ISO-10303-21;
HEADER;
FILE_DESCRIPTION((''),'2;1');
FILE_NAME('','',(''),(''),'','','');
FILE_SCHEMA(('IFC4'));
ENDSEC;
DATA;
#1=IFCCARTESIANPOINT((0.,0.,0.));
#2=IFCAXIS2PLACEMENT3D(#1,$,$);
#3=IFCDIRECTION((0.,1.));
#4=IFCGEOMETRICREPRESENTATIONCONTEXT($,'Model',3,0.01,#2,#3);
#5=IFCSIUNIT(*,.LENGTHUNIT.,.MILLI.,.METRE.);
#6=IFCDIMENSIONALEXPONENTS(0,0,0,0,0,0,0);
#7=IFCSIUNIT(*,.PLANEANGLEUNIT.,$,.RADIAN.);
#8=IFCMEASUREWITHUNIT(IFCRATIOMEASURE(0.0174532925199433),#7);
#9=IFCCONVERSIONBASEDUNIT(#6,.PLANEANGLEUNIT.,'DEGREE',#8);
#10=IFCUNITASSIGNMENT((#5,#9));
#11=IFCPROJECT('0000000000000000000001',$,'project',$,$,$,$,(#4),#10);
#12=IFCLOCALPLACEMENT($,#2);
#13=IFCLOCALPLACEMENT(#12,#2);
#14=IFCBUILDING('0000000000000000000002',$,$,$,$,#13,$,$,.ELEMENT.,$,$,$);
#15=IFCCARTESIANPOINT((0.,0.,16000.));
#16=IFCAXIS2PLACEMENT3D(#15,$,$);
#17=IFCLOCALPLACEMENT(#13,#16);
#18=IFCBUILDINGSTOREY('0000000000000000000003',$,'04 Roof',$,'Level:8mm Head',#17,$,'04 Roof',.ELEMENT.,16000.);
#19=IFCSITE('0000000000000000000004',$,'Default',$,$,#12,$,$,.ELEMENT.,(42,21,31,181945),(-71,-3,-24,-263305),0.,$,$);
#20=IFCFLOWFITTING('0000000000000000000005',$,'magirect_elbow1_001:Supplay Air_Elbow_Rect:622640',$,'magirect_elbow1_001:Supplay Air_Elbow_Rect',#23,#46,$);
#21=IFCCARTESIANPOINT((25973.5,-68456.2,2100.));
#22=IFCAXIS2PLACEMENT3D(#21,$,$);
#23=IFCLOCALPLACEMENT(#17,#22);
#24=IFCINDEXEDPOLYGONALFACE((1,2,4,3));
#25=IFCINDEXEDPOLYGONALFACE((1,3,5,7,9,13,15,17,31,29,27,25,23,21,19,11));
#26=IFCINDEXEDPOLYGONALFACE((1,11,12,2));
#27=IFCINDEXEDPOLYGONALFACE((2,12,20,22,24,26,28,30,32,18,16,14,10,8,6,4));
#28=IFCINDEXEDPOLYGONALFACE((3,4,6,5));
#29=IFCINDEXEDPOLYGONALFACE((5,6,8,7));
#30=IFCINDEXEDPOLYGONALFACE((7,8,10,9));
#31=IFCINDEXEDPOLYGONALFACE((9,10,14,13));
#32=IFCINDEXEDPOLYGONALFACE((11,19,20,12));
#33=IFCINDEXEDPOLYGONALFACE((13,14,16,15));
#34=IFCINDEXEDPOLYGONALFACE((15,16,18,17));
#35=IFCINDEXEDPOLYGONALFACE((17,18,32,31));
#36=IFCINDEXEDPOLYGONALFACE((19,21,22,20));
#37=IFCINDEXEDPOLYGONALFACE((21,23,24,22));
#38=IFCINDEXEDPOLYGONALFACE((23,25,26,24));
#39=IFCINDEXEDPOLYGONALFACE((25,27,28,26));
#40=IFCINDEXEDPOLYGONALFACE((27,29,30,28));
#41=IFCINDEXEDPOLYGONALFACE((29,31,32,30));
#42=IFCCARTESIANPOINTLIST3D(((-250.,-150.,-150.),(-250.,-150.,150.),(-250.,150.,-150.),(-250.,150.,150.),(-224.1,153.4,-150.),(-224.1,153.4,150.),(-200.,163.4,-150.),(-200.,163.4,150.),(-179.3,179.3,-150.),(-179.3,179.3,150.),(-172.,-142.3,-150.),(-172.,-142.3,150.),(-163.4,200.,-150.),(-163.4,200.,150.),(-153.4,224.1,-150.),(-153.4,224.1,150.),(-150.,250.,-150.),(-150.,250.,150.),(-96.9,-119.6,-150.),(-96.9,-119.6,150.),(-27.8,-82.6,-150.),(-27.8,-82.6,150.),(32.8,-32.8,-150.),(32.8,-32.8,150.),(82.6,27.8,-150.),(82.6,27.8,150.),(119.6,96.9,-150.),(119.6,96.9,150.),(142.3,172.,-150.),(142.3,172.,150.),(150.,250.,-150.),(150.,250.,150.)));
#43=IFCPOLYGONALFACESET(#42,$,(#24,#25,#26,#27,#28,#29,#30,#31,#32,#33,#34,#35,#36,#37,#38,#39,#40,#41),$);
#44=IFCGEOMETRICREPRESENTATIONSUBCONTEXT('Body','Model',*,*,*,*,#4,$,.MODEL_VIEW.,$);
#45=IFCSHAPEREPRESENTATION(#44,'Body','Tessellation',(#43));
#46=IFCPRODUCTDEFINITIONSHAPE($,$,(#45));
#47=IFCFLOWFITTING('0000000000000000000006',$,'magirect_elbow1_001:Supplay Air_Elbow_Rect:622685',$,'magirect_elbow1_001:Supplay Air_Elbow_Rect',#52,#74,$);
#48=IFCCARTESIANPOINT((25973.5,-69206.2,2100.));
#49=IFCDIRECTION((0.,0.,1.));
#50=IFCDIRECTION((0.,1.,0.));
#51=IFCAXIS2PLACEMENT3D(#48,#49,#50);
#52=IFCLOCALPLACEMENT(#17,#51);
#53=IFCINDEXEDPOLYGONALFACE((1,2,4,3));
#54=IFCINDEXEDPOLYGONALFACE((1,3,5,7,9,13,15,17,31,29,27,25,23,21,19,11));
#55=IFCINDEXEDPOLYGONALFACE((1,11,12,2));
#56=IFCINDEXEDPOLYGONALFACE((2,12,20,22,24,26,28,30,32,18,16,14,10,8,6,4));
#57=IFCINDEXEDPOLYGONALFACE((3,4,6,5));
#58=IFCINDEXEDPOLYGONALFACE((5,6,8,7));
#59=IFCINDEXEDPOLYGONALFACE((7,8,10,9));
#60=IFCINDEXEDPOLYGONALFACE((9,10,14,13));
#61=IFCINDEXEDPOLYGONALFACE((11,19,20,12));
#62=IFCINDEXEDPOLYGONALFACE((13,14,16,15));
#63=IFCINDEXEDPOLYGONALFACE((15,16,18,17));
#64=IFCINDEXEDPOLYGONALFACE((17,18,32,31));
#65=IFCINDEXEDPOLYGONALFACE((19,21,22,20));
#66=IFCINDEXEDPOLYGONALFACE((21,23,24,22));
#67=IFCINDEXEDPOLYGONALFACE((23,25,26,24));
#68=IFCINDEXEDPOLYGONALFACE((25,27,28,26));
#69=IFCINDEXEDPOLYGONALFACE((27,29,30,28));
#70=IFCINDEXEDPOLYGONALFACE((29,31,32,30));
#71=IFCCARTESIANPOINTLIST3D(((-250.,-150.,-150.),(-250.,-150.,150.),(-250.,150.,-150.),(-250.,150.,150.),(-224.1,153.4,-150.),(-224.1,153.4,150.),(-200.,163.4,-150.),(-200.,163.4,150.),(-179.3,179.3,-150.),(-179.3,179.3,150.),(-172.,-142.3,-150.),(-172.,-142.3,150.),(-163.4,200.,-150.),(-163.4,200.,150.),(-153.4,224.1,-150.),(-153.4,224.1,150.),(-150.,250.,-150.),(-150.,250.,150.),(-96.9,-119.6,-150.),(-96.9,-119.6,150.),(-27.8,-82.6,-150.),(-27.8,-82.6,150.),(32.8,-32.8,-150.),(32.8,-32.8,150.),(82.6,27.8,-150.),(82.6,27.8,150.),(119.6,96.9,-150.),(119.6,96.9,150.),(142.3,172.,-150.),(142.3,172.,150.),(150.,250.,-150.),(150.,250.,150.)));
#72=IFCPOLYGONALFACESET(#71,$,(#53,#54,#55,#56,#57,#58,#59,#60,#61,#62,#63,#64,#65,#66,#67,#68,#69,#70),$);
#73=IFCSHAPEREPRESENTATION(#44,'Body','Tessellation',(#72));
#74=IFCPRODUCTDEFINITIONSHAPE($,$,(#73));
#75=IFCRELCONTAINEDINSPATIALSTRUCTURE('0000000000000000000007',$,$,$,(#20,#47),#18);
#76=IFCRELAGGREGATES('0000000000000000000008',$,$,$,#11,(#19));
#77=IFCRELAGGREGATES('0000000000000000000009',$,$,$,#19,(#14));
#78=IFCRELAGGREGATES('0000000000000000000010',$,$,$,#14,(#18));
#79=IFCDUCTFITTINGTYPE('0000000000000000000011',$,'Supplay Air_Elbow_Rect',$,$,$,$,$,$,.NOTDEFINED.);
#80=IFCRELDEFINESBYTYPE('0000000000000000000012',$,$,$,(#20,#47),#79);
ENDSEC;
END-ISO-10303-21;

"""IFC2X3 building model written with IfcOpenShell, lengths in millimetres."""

from ifc_helpers import new_model, entity, si_unit, converted_unit, direction, frame, frame_2d, origin, place, context, subcontext, project, spatial, polyline, circle_curve, parameter, trimmed, segment, composite_curve, outline, extrude, source, transform, mapped, type_object, type_shapes, element, save


model = new_model("IFC2X3")

# Units and contexts
model_context = context("Model", 3, precision=0.01, world=origin(), true_north=direction((0.0, 1.0)))
body_context = subcontext(model_context, "Body", "Model", "MODEL_VIEW")
ifc_project = project(units=[si_unit("LENGTHUNIT", "METRE", prefix="MILLI"), converted_unit("PLANEANGLEUNIT", "DEGREE", entity("IfcRatioMeasure", 0.0174532925199433), si_unit("PLANEANGLEUNIT", "RADIAN"), dimensions=[0, 0, 0, 0, 0, 0, 0])], contexts=[model_context])

# Site, building, storey
site_placement = place(None, origin())
site = spatial("IfcSite", under=ifc_project, at=site_placement, Name="Default", CompositionType="ELEMENT", RefLatitude=(42, 21, 31, 181945), RefLongitude=(-71, -3, -24, -263305), RefElevation=0.0)
building_placement = place(site_placement, origin())
building = spatial("IfcBuilding", under=site, at=building_placement, CompositionType="ELEMENT")
storey_placement = place(building_placement, frame((0.0, 0.0, 16000.0)))
storey = spatial("IfcBuildingStorey", under=building, at=storey_placement, Name="04 Roof", ObjectType="Level:8mm Head", LongName="04 Roof", CompositionType="ELEMENT", Elevation=16000.0)

# Flow fittings
duct_fitting_type_1 = type_object("IfcDuctFittingType", Name="Supplay Air_Elbow_Rect", PredefinedType="NOTDEFINED")
shared_shape_1 = source(origin(), body_context, "Body", "SweptSolid", [
    extrude(outline(composite_curve([segment(polyline([(-275.0, -125.0), (25.0, -125.0)]), True, "CONTINUOUS"), segment(trimmed(circle_curve(frame_2d((125.0, -125.0), x_axis=(0.0, 1.0)), 100.0), [parameter(0.0)], [parameter(90.0)], True, "PARAMETER"), False, "CONTINUOUS"), segment(polyline([(125.0, -25.0), (125.0, 275.0)]), True, "CONTINUOUS"), segment(trimmed(circle_curve(frame_2d((125.0, -125.0), x_axis=(0.0, 1.0)), 400.0), [parameter(0.0)], [parameter(90.0)], True, "PARAMETER"), True, "CONTINUOUS")], self_intersect=False)), frame((-125.0, 125.0, -150.0), z_axis=(0.0, 0.0, 1.0), x_axis=(-1.0, 0.0, 0.0)), (0.0, 0.0, 1.0), 300.0),
])
type_shapes(duct_fitting_type_1, [shared_shape_1])
flow_fitting_1_placement = place(storey_placement, frame((25973.5, -68456.2, 2100.0)))
element("IfcFlowFitting", 1, at=flow_fitting_1_placement, inside=storey, type_object=duct_fitting_type_1, Name="magirect_elbow1_001:Supplay Air_Elbow_Rect:622640", ObjectType="magirect_elbow1_001:Supplay Air_Elbow_Rect", context=body_context, shape_type="MappedRepresentation", body=[
    mapped(shared_shape_1, transform((0.0, 0.0, 0.0), scale=1.0)),
])
flow_fitting_2_placement = place(storey_placement, frame((25973.5, -69206.2, 2100.0), z_axis=(0.0, 0.0, 1.0), x_axis=(0.0, 1.0, 0.0)))
element("IfcFlowFitting", 2, at=flow_fitting_2_placement, inside=storey, type_object=duct_fitting_type_1, Name="magirect_elbow1_001:Supplay Air_Elbow_Rect:622685", ObjectType="magirect_elbow1_001:Supplay Air_Elbow_Rect", context=body_context, shape_type="MappedRepresentation", body=[
    mapped(shared_shape_1, transform((0.0, 0.0, 0.0), scale=1.0)),
])

save(model, "model.ifc")
